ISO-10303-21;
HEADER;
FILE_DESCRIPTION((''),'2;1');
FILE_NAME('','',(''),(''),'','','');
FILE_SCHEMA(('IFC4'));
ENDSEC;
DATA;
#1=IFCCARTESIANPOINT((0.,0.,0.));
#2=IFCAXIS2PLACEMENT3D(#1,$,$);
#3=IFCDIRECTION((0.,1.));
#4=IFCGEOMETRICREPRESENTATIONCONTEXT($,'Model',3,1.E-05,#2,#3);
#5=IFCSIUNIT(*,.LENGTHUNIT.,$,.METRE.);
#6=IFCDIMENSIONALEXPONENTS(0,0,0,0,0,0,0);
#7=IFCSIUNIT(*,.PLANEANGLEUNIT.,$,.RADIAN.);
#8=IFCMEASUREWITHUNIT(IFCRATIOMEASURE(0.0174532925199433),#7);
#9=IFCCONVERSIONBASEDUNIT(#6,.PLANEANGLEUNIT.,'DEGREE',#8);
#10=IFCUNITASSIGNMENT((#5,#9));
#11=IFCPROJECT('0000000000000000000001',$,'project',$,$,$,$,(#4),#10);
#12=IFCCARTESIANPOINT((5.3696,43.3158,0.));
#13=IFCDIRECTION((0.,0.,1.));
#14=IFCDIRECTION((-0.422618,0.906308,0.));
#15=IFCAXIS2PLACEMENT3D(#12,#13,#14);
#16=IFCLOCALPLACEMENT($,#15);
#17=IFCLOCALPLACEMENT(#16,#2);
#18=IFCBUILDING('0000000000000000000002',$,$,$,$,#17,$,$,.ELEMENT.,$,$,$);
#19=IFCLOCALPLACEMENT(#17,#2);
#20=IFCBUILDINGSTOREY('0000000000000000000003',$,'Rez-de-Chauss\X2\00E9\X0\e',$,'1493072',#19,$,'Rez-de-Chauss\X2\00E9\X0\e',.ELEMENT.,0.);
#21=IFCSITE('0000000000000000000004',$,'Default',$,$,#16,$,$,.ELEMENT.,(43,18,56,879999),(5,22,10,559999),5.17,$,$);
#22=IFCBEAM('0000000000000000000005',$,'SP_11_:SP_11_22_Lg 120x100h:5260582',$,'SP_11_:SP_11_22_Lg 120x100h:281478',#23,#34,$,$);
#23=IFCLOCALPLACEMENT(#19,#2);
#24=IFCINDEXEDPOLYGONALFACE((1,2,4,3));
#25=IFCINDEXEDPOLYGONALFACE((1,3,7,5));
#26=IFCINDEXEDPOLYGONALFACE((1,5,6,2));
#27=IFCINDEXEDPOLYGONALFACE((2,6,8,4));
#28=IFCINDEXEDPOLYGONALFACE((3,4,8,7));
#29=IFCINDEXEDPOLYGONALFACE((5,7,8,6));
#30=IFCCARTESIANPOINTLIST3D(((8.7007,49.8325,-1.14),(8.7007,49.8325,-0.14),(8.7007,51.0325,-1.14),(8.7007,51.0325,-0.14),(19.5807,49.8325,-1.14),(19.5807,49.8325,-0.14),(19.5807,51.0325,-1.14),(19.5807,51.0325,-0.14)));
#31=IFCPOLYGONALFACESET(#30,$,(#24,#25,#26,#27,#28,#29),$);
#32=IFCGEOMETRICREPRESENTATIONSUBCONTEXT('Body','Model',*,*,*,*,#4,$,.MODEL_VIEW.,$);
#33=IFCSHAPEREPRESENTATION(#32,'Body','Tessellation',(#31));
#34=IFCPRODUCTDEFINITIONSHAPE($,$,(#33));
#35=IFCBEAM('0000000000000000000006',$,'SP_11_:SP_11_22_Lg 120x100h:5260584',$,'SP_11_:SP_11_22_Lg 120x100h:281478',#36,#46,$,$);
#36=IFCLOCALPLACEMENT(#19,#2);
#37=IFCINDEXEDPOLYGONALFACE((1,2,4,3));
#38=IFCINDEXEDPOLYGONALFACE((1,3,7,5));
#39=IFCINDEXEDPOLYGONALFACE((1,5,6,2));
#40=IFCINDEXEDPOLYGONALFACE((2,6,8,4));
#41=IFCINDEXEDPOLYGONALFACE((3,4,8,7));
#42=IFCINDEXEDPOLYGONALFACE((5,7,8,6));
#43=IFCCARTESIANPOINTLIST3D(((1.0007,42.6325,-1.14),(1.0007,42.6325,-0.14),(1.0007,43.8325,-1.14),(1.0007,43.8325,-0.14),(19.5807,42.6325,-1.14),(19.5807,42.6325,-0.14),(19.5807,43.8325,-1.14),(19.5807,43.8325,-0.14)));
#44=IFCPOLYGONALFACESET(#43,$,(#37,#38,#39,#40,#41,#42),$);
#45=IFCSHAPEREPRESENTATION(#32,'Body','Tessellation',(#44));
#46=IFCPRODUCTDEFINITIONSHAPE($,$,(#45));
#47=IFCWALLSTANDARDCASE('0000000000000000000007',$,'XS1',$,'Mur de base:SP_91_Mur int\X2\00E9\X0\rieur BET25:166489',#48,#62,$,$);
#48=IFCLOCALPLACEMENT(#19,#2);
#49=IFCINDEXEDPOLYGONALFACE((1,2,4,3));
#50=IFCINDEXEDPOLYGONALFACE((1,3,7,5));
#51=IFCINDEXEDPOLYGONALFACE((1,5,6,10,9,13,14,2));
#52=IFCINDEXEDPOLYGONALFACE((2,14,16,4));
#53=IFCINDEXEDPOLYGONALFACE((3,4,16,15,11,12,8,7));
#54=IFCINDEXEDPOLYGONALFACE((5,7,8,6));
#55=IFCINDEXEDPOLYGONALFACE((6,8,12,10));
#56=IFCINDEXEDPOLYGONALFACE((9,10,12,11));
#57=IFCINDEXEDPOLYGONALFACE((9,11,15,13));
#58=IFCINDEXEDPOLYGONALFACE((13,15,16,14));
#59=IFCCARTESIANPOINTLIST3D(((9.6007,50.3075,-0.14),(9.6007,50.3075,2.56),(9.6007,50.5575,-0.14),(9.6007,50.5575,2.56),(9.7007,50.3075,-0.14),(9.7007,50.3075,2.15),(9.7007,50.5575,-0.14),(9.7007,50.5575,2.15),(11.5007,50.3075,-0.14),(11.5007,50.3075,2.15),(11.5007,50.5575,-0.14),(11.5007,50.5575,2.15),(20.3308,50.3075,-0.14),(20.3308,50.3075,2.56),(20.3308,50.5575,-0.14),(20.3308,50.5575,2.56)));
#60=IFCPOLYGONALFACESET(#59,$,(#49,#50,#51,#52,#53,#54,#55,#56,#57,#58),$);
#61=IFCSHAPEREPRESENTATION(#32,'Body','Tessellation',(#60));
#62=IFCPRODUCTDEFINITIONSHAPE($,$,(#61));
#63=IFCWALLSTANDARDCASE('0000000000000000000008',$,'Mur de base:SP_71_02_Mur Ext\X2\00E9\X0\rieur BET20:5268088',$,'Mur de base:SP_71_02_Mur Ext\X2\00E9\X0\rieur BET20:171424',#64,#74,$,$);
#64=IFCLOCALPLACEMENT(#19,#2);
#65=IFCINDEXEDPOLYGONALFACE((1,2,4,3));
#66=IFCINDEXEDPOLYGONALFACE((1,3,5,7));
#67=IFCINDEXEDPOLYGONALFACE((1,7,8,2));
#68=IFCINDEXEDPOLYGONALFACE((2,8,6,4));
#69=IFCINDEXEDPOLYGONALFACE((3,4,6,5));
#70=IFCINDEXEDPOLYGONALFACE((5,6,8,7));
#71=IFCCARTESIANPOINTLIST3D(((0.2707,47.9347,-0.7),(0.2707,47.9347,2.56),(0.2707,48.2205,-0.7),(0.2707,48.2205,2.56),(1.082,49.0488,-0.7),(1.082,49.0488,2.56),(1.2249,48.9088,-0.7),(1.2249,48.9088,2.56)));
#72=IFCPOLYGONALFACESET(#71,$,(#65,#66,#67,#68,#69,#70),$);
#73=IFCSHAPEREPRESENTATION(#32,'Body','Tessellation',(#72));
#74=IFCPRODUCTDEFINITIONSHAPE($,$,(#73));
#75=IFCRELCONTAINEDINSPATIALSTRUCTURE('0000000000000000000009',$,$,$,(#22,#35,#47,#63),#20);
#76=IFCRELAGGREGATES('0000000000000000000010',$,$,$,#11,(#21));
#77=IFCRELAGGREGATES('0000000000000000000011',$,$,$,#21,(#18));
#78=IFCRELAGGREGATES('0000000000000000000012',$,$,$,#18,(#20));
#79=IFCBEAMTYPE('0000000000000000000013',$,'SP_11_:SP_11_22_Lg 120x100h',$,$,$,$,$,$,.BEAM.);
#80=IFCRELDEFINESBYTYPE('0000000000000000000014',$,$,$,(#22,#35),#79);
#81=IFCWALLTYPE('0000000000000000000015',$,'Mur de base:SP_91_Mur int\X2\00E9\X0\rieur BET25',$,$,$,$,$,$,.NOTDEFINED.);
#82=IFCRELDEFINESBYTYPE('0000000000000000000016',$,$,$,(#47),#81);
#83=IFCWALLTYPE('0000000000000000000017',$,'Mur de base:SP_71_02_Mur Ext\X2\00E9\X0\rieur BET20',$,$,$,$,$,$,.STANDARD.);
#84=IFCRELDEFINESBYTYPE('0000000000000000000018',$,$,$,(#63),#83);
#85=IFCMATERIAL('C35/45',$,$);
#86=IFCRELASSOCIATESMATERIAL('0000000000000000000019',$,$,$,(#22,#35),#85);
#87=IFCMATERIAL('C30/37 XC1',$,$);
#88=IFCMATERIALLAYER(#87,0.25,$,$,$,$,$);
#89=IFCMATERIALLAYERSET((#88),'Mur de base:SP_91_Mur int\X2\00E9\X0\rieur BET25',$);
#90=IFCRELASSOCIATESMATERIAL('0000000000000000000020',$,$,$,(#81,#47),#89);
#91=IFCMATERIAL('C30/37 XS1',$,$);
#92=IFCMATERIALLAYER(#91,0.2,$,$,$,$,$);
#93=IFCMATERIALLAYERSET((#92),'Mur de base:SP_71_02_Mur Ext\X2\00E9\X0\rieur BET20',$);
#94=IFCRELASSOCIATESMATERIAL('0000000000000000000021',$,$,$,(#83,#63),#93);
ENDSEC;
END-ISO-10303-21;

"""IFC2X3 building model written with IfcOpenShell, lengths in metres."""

from ifc_helpers import new_model, entity, si_unit, converted_unit, direction, frame, frame_2d, origin, place, context, subcontext, project, spatial, polyline, rectangle, outline, extrude, clip, halfspace, material, layer, layer_set, layer_usage, type_object, element, save


model = new_model("IFC2X3")

# Units and contexts
model_context = context("Model", 3, precision=1e-05, world=origin(), true_north=direction((0.0, 1.0)))
body_context = subcontext(model_context, "Body", "Model", "MODEL_VIEW")
ifc_project = project(units=[si_unit("LENGTHUNIT", "METRE"), converted_unit("PLANEANGLEUNIT", "DEGREE", entity("IfcRatioMeasure", 0.0174532925199433), si_unit("PLANEANGLEUNIT", "RADIAN"), dimensions=[0, 0, 0, 0, 0, 0, 0])], contexts=[model_context])

# Site, building, storey
site_placement = place(None, frame((5.3696, 43.3158, 0.0), z_axis=(0.0, 0.0, 1.0), x_axis=(-0.422618, 0.906308, 0.0)))
site = spatial("IfcSite", under=ifc_project, at=site_placement, Name="Default", CompositionType="ELEMENT", RefLatitude=(43, 18, 56, 879999), RefLongitude=(5, 22, 10, 559999), RefElevation=5.17)
building_placement = place(site_placement, origin())
building = spatial("IfcBuilding", under=site, at=building_placement, CompositionType="ELEMENT")
storey_placement = place(building_placement, origin())
storey = spatial("IfcBuildingStorey", under=building, at=storey_placement, Name="Rez-de-Chaussée", ObjectType="1493072", LongName="Rez-de-Chaussée", CompositionType="ELEMENT", Elevation=0.0)

# Beams
ifc_material_1 = material(Name="C35/45")
beam_type_1 = type_object("IfcBeamType", Name="SP_11_:SP_11_22_Lg 120x100h", PredefinedType="BEAM")
beam_1_placement = place(storey_placement, frame((19.5807, 50.4325, -0.14), z_axis=(0.0, 0.0, 1.0), x_axis=(-1.0, 0.0, 0.0)))
element("IfcBeam", 1, at=beam_1_placement, inside=storey, type_object=beam_type_1, material=ifc_material_1, Name="SP_11_:SP_11_22_Lg 120x100h:5260582", ObjectType="SP_11_:SP_11_22_Lg 120x100h:281478", context=body_context, shape_type="SweptSolid", body=[
    extrude(rectangle(XDim=1.0, YDim=1.2, at=frame_2d((0.0, 0.0), x_axis=(1.0, 0.0))), frame((0.0, 0.0, -0.5), z_axis=(1.0, 0.0, 0.0), x_axis=(0.0, 0.0, -1.0)), (0.0, 0.0, 1.0), 10.88),
])
beam_2_placement = place(storey_placement, frame((19.5807, 43.2325, -0.14), z_axis=(0.0, 0.0, 1.0), x_axis=(-1.0, 0.0, 0.0)))
element("IfcBeam", 2, at=beam_2_placement, inside=storey, type_object=beam_type_1, material=ifc_material_1, Name="SP_11_:SP_11_22_Lg 120x100h:5260584", ObjectType="SP_11_:SP_11_22_Lg 120x100h:281478", context=body_context, shape_type="SweptSolid", body=[
    extrude(rectangle(XDim=1.0, YDim=1.2, at=frame_2d((0.0, 0.0), x_axis=(1.0, 0.0))), frame((0.0, 0.0, -0.5), z_axis=(1.0, 0.0, 0.0), x_axis=(0.0, 0.0, -1.0)), (0.0, 0.0, 1.0), 18.58),
])

# Wall, opening
ifc_material_2 = material(Name="C30/37 XC1")
ifc_layer_1 = layer(ifc_material_2, 0.25)
ifc_layer_set_1 = layer_set([ifc_layer_1], Name="Mur de base:SP_91_Mur intérieur BET25")
ifc_layer_usage_1 = layer_usage(ifc_layer_set_1, "AXIS2", "NEGATIVE", 0.125)
wall_type_1 = type_object("IfcWallType", Name="Mur de base:SP_91_Mur intérieur BET25", PredefinedType="NOTDEFINED", material=ifc_layer_set_1)
wall_1_placement = place(storey_placement, frame((9.6007, 50.4325, -0.14)))
wall_1 = element("IfcWallStandardCase", 3, at=wall_1_placement, inside=storey, type_object=wall_type_1, material=ifc_layer_usage_1, Name="XS1", ObjectType="Mur de base:SP_91_Mur intérieur BET25:166489", context=body_context, shape_type="Clipping", body=[
    clip(extrude(rectangle(XDim=10.7301, YDim=0.25, at=frame_2d((5.365, 0.0), x_axis=(-1.0, 0.0))), origin(), (0.0, 0.0, 1.0), 2.7), halfspace(frame((0.0, 0.0, -0.14)), True)),
])
opening_1_placement = place(wall_1_placement, origin())
element("IfcOpeningElement", 4, at=opening_1_placement, cuts=wall_1, ObjectType="Opening", context=body_context, shape_type="SweptSolid", body=[
    extrude(rectangle(XDim=2.29, YDim=1.8, at=frame_2d((0.0, 0.0), x_axis=(1.0, 0.0))), frame((1.0, -1.399, 1.145), z_axis=(0.0, 1.0, 0.0), x_axis=(0.0, 0.0, -1.0)), (0.0, 0.0, 1.0), 3.048),
])

# Wall
ifc_material_3 = material(Name="C30/37 XS1")
ifc_layer_2 = layer(ifc_material_3, 0.2)
ifc_layer_set_2 = layer_set([ifc_layer_2], Name="Mur de base:SP_71_02_Mur Extérieur BET20")
wall_type_2 = type_object("IfcWallType", Name="Mur de base:SP_71_02_Mur Extérieur BET20", PredefinedType="STANDARD", material=ifc_layer_set_2)
ifc_layer_usage_2 = layer_usage(ifc_layer_set_2, "AXIS2", "NEGATIVE", 0.1)
wall_2_placement = place(storey_placement, frame((1.1535, 48.9788, -0.7), z_axis=(0.0, 0.0, 1.0), x_axis=(-0.699774, -0.714364, 0.0)))
element("IfcWallStandardCase", 5, at=wall_2_placement, inside=storey, type_object=wall_type_2, material=ifc_layer_usage_2, Name="Mur de base:SP_71_02_Mur Extérieur BET20:5268088", ObjectType="Mur de base:SP_71_02_Mur Extérieur BET20:171424", context=body_context, shape_type="Clipping", body=[
    clip(extrude(outline(polyline([(1.1595, -0.1), (1.3636, 0.1), (1.0769, 0.1), (0.3204, 0.1), (0.0, 0.1), (0.0, -0.1), (0.1163, -0.1), (1.0769, -0.1), (1.1595, -0.1)])), origin(), (0.0, 0.0, 1.0), 3.26), halfspace(frame((0.0, 0.0, -0.7)), True)),
])

save(model, "model.ifc")
